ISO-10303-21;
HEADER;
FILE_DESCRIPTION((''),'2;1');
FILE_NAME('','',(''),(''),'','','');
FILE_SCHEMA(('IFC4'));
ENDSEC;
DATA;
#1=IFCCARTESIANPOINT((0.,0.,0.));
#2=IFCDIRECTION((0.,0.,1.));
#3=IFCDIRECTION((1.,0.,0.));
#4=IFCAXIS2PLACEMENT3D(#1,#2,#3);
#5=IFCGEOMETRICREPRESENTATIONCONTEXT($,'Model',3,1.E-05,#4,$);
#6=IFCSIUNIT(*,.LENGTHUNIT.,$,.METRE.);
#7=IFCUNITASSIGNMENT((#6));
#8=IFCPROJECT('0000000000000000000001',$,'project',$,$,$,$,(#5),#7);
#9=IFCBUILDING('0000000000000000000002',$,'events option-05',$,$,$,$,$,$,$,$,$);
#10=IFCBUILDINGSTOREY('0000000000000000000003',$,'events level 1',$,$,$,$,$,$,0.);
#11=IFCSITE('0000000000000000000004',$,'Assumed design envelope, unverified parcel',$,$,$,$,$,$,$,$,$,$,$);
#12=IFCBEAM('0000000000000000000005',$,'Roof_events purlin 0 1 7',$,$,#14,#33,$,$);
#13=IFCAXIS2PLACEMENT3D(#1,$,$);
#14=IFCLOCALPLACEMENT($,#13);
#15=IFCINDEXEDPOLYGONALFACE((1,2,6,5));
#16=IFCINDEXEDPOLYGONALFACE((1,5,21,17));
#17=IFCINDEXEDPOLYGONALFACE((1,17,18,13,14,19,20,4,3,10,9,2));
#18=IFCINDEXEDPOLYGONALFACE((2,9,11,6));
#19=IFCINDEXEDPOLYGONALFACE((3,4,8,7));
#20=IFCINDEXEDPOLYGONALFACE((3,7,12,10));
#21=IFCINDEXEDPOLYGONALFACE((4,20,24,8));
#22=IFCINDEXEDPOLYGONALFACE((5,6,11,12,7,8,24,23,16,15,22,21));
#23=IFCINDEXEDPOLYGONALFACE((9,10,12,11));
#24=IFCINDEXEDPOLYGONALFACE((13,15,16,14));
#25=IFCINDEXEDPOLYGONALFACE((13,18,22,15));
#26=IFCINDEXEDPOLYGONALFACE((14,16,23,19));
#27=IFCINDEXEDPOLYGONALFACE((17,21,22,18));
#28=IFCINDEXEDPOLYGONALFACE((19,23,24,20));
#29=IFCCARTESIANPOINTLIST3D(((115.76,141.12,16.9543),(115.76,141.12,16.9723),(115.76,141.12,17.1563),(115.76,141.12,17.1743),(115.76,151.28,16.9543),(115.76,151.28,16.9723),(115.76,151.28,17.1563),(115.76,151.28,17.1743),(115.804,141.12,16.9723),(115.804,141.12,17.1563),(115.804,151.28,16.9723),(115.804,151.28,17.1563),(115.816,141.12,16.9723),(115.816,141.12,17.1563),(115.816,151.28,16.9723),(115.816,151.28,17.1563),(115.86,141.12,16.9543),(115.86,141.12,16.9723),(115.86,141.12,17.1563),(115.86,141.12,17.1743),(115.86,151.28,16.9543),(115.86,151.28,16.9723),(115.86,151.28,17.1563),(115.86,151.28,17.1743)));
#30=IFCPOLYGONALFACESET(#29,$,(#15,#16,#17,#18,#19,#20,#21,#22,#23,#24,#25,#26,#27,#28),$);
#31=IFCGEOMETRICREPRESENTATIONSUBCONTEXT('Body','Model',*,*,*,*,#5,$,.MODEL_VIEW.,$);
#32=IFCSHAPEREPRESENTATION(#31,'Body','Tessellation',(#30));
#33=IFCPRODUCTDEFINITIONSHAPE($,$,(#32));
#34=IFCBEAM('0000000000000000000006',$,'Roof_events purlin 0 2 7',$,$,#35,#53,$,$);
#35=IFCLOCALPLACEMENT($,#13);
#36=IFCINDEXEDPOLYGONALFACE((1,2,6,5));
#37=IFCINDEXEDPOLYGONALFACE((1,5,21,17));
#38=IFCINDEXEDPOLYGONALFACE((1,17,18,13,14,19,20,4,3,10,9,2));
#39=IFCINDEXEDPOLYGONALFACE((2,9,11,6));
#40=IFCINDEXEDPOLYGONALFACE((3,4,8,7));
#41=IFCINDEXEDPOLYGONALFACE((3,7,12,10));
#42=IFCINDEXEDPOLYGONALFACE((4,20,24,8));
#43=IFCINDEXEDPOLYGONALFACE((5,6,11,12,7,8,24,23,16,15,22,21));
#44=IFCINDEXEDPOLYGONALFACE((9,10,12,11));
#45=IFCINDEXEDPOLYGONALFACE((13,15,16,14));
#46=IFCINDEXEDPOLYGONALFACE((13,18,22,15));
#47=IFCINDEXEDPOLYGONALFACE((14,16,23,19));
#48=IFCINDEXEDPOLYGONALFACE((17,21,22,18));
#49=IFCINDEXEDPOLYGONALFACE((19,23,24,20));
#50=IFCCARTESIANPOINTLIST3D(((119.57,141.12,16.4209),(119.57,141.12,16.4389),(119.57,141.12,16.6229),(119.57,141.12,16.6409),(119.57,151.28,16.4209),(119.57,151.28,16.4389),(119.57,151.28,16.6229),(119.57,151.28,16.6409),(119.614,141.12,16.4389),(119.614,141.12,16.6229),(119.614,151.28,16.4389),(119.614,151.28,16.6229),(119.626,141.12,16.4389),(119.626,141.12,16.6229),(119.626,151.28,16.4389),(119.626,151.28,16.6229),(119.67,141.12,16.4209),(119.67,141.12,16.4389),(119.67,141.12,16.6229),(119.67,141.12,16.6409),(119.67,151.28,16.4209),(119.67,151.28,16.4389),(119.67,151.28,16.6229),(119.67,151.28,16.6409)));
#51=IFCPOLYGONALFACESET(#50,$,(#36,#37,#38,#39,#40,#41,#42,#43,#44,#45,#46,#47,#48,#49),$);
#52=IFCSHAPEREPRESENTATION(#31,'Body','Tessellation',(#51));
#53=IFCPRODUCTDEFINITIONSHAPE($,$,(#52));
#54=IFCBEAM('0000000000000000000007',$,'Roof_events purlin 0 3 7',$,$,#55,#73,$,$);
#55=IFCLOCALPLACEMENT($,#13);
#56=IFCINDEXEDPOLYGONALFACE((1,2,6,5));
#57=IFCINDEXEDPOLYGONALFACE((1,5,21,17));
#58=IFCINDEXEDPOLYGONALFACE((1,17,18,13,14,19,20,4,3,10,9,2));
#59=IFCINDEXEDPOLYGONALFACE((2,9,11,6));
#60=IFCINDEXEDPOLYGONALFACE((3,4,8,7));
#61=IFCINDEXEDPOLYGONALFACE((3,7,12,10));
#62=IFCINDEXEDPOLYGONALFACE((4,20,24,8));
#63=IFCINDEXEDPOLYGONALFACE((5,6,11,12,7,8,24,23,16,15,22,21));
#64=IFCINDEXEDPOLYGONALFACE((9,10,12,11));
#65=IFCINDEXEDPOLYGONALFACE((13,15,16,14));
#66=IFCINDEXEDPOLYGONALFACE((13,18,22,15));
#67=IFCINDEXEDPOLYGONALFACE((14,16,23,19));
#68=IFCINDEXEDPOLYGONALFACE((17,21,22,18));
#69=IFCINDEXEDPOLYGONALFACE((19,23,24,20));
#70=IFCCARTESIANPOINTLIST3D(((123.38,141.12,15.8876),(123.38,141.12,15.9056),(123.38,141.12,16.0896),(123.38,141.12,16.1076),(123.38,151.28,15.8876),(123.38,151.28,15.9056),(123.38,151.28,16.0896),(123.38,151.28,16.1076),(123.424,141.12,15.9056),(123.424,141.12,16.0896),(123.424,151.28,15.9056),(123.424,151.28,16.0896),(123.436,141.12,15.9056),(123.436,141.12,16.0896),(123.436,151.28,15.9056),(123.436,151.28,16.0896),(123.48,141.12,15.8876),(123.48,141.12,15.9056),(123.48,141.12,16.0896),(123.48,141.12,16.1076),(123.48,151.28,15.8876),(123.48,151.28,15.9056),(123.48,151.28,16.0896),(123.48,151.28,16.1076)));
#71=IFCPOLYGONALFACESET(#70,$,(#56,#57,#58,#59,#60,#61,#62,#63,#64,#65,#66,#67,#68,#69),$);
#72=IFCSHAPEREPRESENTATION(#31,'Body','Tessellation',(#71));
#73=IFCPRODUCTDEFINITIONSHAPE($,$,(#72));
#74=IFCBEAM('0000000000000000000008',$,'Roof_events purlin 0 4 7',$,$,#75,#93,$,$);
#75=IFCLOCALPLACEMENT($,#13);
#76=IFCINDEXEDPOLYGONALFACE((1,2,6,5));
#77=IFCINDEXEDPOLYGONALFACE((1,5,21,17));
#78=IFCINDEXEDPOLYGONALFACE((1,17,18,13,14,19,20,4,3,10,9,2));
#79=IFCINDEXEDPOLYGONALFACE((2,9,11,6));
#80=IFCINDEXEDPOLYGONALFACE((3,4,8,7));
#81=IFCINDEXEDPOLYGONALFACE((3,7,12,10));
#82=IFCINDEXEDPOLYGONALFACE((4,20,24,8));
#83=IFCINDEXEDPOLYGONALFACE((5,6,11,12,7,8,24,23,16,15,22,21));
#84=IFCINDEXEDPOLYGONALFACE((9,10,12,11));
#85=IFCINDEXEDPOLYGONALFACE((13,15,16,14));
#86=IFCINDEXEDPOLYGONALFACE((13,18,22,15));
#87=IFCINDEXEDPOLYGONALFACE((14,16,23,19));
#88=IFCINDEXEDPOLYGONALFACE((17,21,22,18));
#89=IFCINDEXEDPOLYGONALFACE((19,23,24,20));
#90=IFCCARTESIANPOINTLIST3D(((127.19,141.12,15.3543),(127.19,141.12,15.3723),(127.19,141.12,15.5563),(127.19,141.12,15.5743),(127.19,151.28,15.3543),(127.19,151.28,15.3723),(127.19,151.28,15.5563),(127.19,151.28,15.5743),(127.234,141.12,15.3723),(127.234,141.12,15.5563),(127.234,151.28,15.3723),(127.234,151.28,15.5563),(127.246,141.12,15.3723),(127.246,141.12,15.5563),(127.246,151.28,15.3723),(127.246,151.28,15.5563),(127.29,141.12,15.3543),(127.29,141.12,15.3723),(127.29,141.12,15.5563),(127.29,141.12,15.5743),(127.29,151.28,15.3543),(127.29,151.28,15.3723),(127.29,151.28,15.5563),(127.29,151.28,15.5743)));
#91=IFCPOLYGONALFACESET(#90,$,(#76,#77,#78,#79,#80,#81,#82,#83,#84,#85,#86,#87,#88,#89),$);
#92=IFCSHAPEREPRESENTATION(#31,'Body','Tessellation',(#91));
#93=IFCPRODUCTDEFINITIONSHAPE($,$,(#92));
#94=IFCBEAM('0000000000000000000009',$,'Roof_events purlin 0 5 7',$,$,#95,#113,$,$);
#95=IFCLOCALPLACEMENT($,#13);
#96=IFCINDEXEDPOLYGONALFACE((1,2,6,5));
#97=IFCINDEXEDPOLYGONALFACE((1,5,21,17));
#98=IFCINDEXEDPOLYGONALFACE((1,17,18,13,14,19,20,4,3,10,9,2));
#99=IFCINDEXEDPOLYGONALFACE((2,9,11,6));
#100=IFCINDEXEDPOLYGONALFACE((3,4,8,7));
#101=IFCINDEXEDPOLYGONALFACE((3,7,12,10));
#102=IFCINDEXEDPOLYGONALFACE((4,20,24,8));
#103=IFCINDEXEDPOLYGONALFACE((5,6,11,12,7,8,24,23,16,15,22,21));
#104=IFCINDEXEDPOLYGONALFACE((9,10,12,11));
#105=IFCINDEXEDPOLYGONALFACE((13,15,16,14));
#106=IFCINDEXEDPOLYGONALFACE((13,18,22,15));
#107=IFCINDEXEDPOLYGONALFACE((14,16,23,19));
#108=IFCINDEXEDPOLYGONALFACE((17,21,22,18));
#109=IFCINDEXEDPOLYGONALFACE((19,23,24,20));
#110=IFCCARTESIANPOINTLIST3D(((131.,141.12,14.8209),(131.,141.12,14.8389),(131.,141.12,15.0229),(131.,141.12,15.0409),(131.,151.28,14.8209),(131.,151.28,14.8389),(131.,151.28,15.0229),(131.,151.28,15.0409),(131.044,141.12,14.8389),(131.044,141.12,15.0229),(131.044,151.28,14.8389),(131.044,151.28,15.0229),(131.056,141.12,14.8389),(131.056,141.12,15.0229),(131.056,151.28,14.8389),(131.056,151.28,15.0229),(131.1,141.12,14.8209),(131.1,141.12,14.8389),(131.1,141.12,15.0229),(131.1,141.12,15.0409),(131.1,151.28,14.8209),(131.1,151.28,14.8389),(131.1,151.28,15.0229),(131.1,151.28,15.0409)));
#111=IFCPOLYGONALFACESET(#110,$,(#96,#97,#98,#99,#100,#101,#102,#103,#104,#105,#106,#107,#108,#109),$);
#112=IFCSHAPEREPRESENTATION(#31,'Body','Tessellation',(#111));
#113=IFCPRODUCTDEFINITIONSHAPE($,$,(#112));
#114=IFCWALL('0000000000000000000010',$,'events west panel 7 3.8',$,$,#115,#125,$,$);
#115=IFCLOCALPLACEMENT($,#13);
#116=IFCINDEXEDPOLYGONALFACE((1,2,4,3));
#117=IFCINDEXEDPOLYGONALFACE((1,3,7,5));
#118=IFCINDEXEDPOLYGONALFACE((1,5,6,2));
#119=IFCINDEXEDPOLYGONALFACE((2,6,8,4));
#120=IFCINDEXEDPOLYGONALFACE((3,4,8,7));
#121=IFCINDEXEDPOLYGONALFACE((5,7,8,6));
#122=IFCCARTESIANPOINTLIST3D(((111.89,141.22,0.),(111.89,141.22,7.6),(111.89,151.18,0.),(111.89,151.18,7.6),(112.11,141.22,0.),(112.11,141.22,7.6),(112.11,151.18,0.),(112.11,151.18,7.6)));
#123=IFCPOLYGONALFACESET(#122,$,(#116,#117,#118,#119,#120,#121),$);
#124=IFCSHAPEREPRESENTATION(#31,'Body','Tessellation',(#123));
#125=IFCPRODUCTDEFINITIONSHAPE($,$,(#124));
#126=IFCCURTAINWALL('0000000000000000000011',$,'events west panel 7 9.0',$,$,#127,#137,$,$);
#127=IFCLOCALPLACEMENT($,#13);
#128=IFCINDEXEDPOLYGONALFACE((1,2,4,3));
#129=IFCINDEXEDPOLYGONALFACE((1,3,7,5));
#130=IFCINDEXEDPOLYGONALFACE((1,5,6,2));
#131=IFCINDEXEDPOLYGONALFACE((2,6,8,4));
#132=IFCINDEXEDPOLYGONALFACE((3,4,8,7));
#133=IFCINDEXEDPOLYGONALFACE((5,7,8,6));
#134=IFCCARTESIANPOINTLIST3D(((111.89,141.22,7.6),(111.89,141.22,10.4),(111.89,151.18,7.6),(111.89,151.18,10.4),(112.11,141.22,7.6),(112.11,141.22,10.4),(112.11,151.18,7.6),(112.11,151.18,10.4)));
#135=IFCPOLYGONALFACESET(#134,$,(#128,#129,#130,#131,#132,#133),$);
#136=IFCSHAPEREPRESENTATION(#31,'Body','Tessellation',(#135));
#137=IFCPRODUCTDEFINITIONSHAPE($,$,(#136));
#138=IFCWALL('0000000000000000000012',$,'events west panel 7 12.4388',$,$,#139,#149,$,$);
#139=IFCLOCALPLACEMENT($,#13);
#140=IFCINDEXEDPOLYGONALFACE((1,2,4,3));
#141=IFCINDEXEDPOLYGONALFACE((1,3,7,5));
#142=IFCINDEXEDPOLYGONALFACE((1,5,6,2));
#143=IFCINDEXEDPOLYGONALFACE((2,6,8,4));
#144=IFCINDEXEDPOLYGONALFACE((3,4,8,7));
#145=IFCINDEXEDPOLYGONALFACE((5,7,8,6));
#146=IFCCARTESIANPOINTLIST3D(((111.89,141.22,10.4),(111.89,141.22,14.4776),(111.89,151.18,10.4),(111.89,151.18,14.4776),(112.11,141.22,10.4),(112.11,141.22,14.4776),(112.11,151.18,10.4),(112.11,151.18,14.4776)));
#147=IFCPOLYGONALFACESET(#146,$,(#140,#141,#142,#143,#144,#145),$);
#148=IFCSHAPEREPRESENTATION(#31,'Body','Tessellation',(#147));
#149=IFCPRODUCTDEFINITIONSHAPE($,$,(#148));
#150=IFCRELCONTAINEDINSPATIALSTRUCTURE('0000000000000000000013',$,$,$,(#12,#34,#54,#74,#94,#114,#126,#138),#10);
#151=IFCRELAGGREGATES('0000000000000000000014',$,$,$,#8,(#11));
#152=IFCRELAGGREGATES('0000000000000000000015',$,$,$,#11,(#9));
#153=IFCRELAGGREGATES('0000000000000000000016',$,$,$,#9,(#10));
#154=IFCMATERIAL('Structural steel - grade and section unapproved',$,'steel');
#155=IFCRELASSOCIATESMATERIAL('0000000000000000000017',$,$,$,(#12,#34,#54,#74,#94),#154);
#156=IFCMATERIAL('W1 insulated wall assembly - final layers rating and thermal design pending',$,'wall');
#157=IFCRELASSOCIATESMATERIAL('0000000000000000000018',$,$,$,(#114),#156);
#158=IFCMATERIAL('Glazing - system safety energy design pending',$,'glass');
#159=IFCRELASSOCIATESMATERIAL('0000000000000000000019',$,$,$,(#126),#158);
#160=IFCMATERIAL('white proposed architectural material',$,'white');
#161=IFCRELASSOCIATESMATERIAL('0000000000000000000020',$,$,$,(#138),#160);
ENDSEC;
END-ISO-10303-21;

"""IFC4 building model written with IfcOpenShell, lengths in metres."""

from ifc_helpers import new_model, si_unit, frame, origin_with_axes, place, context, subcontext, project, spatial, rectangle, i_section, extrude, material, element, save


model = new_model("IFC4")

# Units and contexts
model_context = context("Model", 3, precision=1e-05, world=origin_with_axes())
body_context = subcontext(model_context, "Body", "Model", "MODEL_VIEW")
ifc_project = project(units=[si_unit("LENGTHUNIT", "METRE")], contexts=[model_context])

# Site, building, storey
site = spatial("IfcSite", under=ifc_project, Name="Assumed design envelope, unverified parcel")
building = spatial("IfcBuilding", under=site, Name="events option-05")
storey = spatial("IfcBuildingStorey", under=building, Name="events level 1", Elevation=0.0)

# Shared definitions
ifc_material_1 = material(Name="Structural steel - grade and section unapproved", Category="steel")

# Beams
for number, where, z_axis, x_axis, name in (
    (1, (115.81, 141.12, 17.0643), (0.0, 1.0, 0.0), (-1.0, 0.0, 0.0), "Roof_events purlin 0 1 7"),
    (2, (119.62, 141.12, 16.5309), (0.0, 1.0, 0.0), (-1.0, 0.0, 0.0), "Roof_events purlin 0 2 7"),
    (3, (123.43, 141.12, 15.9976), (0.0, 1.0, 0.0), (-1.0, 0.0, 0.0), "Roof_events purlin 0 3 7"),
    (4, (127.24, 141.12, 15.4643), (0.0, 1.0, 0.0), (-1.0, 0.0, 0.0), "Roof_events purlin 0 4 7"),
    (5, (131.05, 141.12, 14.9309), (0.0, 1.0, 0.0), (-1.0, 0.0, 0.0), "Roof_events purlin 0 5 7"),
):
    element("IfcBeam", number, at=place(None, frame(where, z_axis=z_axis, x_axis=x_axis)), inside=storey, material=ifc_material_1, Name=name, context=body_context, shape_type="SweptSolid", body=[
        extrude(i_section(OverallWidth=0.1, OverallDepth=0.22, WebThickness=0.012, FlangeThickness=0.018, FilletRadius=0.0), origin_with_axes(), (0.0, 0.0, 1.0), 10.16),
    ])

# Wall
ifc_material_2 = material(Name="W1 insulated wall assembly - final layers rating and thermal design pending", Category="wall")
wall_1_placement = place(None, frame((112.0, 146.2, 0.0), z_axis=(0.0, 0.0, 1.0), x_axis=(1.0, 0.0, 0.0)))
element("IfcWall", 6, at=wall_1_placement, inside=storey, material=ifc_material_2, Name="events west panel 7 3.8", context=body_context, shape_type="SweptSolid", body=[
    extrude(rectangle(XDim=0.22, YDim=9.96), origin_with_axes(), (0.0, 0.0, 1.0), 7.6),
])

# Curtain wall
ifc_material_3 = material(Name="Glazing - system safety energy design pending", Category="glass")
curtain_wall_placement = place(None, frame((112.0, 146.2, 7.6), z_axis=(0.0, 0.0, 1.0), x_axis=(1.0, 0.0, 0.0)))
element("IfcCurtainWall", 7, at=curtain_wall_placement, inside=storey, material=ifc_material_3, Name="events west panel 7 9.0", context=body_context, shape_type="SweptSolid", body=[
    extrude(rectangle(XDim=0.22, YDim=9.96), origin_with_axes(), (0.0, 0.0, 1.0), 2.8),
])

# Wall
ifc_material_4 = material(Name="white proposed architectural material", Category="white")
wall_2_placement = place(None, frame((112.0, 146.2, 10.4), z_axis=(0.0, 0.0, 1.0), x_axis=(1.0, 0.0, 0.0)))
element("IfcWall", 8, at=wall_2_placement, inside=storey, material=ifc_material_4, Name="events west panel 7 12.4388", context=body_context, shape_type="SweptSolid", body=[
    extrude(rectangle(XDim=0.22, YDim=9.96), origin_with_axes(), (0.0, 0.0, 1.0), 4.0776),
])

save(model, "model.ifc")
